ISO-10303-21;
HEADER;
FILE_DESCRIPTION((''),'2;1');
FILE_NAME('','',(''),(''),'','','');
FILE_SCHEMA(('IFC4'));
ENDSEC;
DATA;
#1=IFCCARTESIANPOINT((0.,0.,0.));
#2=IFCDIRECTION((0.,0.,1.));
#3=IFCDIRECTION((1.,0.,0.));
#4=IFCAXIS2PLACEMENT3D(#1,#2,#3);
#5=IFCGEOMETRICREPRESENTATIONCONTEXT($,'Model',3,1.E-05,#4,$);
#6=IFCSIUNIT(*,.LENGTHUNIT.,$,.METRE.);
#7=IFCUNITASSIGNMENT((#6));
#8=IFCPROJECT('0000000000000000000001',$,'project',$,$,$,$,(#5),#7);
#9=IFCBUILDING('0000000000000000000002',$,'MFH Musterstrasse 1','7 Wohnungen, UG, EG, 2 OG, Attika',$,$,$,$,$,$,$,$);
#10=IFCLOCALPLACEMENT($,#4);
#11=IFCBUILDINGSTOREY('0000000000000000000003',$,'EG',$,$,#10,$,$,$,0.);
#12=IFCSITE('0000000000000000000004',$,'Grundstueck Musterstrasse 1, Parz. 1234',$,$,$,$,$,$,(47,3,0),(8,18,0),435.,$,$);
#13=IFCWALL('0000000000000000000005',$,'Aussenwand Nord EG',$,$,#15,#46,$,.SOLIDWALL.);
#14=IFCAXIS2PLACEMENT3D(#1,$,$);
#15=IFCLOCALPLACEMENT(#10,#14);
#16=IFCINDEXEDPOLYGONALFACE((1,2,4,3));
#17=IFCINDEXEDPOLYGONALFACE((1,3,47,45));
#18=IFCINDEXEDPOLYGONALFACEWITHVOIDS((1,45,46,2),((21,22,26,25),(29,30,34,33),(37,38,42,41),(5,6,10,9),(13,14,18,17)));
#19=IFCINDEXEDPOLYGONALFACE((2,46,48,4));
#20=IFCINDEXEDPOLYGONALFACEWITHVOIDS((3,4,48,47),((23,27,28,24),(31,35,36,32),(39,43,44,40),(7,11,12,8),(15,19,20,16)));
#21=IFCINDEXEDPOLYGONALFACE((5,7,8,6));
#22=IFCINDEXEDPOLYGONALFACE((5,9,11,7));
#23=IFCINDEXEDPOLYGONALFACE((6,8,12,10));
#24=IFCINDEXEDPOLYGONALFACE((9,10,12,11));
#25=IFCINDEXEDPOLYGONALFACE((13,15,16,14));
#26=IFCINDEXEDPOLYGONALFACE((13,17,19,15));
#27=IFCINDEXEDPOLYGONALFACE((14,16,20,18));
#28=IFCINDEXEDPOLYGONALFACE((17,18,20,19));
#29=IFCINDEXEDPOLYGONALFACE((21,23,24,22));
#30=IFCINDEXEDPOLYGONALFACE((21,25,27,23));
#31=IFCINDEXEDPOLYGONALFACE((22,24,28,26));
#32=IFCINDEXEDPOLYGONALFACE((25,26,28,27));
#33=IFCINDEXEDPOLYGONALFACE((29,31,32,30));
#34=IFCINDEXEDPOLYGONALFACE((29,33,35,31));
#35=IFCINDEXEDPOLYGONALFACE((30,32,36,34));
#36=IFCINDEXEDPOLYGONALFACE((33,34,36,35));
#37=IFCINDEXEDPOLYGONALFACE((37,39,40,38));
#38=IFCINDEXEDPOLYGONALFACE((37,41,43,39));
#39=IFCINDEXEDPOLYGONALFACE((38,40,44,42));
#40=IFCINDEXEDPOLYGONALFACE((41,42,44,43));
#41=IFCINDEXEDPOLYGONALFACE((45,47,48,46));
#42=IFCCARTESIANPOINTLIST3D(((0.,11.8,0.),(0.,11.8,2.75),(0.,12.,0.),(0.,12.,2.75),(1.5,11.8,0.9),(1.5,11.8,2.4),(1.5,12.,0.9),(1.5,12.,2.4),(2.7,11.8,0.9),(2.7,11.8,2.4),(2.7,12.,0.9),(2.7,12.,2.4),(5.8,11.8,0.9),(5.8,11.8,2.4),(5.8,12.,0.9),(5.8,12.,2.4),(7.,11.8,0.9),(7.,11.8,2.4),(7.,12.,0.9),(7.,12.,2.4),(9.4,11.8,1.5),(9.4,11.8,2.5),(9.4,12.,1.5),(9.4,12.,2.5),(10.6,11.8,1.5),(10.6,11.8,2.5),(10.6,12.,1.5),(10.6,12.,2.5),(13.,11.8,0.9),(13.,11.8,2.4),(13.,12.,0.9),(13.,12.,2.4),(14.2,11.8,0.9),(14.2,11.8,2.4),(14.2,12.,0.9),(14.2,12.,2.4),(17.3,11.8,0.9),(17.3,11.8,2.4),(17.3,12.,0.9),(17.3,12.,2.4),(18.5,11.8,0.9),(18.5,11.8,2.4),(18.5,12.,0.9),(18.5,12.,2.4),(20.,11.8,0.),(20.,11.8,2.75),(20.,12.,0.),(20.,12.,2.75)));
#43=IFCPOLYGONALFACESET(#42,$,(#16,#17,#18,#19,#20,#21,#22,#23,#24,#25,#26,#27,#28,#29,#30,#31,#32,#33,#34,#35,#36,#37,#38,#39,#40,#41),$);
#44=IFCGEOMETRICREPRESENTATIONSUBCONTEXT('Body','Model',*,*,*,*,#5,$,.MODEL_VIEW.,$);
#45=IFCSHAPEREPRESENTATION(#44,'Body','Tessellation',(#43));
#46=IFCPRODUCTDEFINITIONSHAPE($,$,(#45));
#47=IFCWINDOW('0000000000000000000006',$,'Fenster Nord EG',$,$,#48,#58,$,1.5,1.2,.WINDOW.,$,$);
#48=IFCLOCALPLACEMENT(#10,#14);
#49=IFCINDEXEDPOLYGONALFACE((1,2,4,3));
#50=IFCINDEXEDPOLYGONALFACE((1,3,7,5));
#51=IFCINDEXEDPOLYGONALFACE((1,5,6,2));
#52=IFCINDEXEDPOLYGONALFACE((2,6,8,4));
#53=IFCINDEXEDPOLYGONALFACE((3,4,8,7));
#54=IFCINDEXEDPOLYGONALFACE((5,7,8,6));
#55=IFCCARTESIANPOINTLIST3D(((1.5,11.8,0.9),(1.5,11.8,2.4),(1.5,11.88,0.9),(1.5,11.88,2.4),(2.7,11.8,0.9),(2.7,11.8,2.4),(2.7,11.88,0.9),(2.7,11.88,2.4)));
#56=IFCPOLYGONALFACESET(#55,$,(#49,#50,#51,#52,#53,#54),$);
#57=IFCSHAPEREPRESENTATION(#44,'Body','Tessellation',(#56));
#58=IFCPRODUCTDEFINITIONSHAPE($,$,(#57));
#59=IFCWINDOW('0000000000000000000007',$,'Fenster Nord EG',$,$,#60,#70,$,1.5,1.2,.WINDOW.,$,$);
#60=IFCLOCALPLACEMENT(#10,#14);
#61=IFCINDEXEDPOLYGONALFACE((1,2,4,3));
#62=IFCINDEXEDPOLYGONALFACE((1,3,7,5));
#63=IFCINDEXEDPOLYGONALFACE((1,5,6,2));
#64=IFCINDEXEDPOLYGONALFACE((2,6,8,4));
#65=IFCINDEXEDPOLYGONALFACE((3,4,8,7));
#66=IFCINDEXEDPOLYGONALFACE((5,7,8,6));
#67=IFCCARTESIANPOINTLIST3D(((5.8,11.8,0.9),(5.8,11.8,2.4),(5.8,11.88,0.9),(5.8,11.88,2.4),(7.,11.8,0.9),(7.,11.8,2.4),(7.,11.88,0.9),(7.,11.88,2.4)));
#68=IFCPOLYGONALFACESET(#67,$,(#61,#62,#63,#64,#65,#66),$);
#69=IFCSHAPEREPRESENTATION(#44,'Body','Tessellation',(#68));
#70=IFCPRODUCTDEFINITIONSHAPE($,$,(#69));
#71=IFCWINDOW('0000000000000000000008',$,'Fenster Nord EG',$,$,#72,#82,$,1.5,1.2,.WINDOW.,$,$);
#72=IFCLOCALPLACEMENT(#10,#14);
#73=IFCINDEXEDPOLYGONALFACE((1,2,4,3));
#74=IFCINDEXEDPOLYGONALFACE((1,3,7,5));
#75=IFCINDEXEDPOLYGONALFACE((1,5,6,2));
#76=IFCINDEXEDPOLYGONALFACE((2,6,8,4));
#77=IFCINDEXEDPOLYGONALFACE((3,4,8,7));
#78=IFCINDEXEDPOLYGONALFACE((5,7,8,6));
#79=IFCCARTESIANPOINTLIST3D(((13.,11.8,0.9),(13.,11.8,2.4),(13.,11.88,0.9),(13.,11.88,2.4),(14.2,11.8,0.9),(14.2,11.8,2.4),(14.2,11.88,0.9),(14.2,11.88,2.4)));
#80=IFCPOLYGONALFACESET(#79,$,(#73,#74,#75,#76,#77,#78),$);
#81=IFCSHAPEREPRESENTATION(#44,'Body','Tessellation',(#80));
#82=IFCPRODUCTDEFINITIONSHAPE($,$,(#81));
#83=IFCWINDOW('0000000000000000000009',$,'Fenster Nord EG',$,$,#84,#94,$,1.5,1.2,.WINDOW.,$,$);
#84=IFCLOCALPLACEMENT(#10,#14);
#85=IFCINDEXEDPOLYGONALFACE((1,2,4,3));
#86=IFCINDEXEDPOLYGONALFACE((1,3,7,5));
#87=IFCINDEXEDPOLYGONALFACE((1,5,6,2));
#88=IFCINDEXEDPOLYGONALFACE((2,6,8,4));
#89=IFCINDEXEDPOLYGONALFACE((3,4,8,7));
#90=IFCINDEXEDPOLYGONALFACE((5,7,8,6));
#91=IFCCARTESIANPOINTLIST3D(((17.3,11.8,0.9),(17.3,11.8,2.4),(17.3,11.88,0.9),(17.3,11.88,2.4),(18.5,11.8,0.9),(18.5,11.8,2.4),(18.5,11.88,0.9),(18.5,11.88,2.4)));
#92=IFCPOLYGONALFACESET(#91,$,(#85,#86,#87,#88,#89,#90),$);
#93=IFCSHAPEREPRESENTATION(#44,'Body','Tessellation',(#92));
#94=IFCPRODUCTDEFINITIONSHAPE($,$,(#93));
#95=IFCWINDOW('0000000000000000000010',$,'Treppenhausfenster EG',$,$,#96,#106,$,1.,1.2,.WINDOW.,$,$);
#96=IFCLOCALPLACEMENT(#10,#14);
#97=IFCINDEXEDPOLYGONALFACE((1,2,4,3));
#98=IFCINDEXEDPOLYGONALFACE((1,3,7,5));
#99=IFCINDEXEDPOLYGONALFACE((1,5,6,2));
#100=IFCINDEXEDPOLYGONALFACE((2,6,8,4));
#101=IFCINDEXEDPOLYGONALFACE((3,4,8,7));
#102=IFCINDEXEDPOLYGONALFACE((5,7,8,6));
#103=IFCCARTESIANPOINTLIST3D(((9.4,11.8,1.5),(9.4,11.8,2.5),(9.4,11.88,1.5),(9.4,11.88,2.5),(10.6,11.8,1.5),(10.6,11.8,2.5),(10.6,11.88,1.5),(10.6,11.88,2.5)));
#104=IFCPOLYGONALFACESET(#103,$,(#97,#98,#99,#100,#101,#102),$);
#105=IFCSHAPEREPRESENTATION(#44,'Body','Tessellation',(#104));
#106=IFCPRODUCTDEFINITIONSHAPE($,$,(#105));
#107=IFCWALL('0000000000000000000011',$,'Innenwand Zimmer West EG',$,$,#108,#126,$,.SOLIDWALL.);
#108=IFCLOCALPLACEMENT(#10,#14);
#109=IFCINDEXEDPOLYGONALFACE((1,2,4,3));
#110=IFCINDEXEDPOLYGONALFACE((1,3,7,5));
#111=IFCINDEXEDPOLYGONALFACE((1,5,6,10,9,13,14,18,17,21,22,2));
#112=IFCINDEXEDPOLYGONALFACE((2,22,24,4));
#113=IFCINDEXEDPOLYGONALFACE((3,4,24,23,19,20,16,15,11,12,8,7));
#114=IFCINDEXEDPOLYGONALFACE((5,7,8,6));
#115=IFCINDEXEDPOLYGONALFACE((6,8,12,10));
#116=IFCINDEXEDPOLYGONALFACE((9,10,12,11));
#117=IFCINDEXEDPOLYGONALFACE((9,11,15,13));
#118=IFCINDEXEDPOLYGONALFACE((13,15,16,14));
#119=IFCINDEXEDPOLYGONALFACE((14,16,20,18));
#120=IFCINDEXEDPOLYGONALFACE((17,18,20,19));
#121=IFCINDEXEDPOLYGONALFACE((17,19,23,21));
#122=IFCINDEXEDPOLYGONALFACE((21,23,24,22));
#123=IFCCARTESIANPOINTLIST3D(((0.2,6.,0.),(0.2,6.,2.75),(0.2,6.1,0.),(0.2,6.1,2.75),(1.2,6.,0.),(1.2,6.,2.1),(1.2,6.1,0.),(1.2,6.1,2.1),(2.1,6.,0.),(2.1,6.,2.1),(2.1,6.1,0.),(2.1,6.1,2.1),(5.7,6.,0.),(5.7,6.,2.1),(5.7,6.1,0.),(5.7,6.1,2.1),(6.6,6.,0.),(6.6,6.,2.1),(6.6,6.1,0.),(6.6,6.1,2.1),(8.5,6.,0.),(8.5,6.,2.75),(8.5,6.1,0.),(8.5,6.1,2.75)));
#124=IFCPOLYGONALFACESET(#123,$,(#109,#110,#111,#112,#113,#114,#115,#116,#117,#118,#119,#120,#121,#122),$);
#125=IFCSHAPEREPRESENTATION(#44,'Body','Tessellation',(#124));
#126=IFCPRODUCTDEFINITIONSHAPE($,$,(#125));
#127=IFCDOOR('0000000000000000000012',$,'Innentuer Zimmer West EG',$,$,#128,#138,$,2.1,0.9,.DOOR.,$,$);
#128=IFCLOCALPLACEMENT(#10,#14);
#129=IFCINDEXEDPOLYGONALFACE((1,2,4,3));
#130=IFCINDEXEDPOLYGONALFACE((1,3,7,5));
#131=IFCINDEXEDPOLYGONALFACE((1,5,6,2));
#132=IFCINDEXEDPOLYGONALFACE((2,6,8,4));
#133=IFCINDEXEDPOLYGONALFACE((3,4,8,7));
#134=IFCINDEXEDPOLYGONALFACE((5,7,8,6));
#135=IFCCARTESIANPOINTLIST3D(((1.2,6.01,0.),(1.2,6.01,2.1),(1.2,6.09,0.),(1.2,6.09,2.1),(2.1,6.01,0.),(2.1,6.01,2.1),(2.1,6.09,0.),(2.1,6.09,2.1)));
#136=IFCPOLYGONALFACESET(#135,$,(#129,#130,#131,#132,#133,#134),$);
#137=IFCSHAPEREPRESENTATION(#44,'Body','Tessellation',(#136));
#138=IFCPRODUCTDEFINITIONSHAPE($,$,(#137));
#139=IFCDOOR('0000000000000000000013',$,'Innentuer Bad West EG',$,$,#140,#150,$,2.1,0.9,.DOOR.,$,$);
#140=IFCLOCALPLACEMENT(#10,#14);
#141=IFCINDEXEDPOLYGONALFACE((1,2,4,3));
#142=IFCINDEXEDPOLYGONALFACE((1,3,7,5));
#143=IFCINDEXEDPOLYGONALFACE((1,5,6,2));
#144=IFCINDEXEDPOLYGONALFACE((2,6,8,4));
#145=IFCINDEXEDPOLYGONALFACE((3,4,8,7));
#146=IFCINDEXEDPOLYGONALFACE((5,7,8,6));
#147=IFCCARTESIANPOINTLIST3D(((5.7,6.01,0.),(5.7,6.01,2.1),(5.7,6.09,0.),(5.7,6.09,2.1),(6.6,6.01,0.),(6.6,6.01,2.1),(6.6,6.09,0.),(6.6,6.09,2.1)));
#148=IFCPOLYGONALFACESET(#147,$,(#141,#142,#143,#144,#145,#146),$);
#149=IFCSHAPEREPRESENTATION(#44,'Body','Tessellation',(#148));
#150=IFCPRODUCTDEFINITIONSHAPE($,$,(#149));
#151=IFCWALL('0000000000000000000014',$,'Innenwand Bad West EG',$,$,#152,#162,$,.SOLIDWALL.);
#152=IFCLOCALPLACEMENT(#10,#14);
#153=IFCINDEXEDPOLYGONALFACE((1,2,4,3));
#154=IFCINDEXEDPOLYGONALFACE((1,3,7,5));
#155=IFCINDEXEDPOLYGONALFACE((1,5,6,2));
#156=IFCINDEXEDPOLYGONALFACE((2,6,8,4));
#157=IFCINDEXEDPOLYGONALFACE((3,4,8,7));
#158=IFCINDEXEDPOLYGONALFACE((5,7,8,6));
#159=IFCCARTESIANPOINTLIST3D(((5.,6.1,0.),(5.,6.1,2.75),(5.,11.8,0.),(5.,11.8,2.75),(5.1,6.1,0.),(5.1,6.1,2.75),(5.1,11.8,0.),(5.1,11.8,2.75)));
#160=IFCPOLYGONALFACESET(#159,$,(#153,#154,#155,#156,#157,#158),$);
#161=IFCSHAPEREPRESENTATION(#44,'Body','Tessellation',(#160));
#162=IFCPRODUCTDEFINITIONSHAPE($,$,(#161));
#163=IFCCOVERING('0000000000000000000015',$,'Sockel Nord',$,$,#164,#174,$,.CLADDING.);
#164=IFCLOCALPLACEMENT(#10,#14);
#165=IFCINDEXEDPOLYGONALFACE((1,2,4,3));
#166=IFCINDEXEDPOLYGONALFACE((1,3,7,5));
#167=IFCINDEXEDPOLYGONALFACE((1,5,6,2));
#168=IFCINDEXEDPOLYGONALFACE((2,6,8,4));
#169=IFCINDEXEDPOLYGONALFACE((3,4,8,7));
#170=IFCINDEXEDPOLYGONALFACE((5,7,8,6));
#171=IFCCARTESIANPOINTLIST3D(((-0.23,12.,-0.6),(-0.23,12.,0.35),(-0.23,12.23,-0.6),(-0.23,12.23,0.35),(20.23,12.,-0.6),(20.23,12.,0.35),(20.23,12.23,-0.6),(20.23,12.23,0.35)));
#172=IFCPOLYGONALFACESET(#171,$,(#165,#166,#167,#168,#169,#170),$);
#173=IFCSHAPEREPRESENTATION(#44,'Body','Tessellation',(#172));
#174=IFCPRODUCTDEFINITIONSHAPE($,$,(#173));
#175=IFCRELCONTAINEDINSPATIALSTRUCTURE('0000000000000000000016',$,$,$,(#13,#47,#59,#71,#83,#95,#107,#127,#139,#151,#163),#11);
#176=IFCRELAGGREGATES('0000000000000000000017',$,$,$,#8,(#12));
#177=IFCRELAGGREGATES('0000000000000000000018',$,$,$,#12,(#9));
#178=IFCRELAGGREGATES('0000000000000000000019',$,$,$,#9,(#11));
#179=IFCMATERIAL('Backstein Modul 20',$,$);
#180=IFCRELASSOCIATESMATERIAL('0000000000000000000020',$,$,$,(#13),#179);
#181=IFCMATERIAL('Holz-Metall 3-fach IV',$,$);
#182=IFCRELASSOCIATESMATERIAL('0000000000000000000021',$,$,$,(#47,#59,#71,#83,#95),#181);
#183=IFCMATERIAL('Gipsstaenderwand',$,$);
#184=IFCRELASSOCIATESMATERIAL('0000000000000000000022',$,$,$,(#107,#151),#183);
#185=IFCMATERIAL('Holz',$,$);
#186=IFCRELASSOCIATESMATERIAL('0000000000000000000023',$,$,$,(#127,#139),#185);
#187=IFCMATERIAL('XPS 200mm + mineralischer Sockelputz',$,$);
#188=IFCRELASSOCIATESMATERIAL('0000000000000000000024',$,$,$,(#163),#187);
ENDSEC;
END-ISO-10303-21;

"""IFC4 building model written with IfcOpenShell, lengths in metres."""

from ifc_helpers import new_model, si_unit, frame, frame_2d, origin_with_axes, place, context, subcontext, project, spatial, rectangle, extrude, material, element, fill, save


model = new_model("IFC4")

# Units and contexts
model_context = context("Model", 3, precision=1e-05, world=origin_with_axes())
body_context = subcontext(model_context, "Body", "Model", "MODEL_VIEW")
ifc_project = project(units=[si_unit("LENGTHUNIT", "METRE")], contexts=[model_context])

# Site, building, storey
site = spatial("IfcSite", under=ifc_project, Name="Grundstueck Musterstrasse 1, Parz. 1234", RefLatitude=(47, 3, 0), RefLongitude=(8, 18, 0), RefElevation=435.0)
building = spatial("IfcBuilding", under=site, Name="MFH Musterstrasse 1", Description="7 Wohnungen, UG, EG, 2 OG, Attika")
storey_placement = place(None, origin_with_axes())
storey = spatial("IfcBuildingStorey", under=building, at=storey_placement, Name="EG", Elevation=0.0)

# Wall, openings, windows
ifc_material_1 = material(Name="Backstein Modul 20")
wall_1_placement = place(storey_placement, frame((0.0, 11.8, 0.0), z_axis=(0.0, 0.0, 1.0), x_axis=(1.0, 0.0, 0.0)))
wall_1 = element("IfcWall", 1, at=wall_1_placement, inside=storey, material=ifc_material_1, Name="Aussenwand Nord EG", PredefinedType="SOLIDWALL", context=body_context, shape_type="SweptSolid", body=[
    extrude(rectangle(XDim=20.0, YDim=0.2, at=frame_2d((10.0, 0.1))), origin_with_axes(), (0.0, 0.0, 1.0), 2.75),
])
opening_1_placement = place(wall_1_placement, frame((1.5, -0.01, 0.9), z_axis=(0.0, 0.0, 1.0), x_axis=(1.0, 0.0, 0.0)))
opening_1 = element("IfcOpeningElement", 2, at=opening_1_placement, cuts=wall_1, context=body_context, shape_type="SweptSolid", body=[
    extrude(rectangle(XDim=1.2, YDim=0.42, at=frame_2d((0.6, 0.21))), origin_with_axes(), (0.0, 0.0, 1.0), 1.5),
])
opening_2_placement = place(wall_1_placement, frame((5.8, -0.01, 0.9), z_axis=(0.0, 0.0, 1.0), x_axis=(1.0, 0.0, 0.0)))
opening_2 = element("IfcOpeningElement", 3, at=opening_2_placement, cuts=wall_1, context=body_context, shape_type="SweptSolid", body=[
    extrude(rectangle(XDim=1.2, YDim=0.42, at=frame_2d((0.6, 0.21))), origin_with_axes(), (0.0, 0.0, 1.0), 1.5),
])
opening_3_placement = place(wall_1_placement, frame((13.0, -0.01, 0.9), z_axis=(0.0, 0.0, 1.0), x_axis=(1.0, 0.0, 0.0)))
opening_3 = element("IfcOpeningElement", 4, at=opening_3_placement, cuts=wall_1, context=body_context, shape_type="SweptSolid", body=[
    extrude(rectangle(XDim=1.2, YDim=0.42, at=frame_2d((0.6, 0.21))), origin_with_axes(), (0.0, 0.0, 1.0), 1.5),
])
opening_4_placement = place(wall_1_placement, frame((17.3, -0.01, 0.9), z_axis=(0.0, 0.0, 1.0), x_axis=(1.0, 0.0, 0.0)))
opening_4 = element("IfcOpeningElement", 5, at=opening_4_placement, cuts=wall_1, context=body_context, shape_type="SweptSolid", body=[
    extrude(rectangle(XDim=1.2, YDim=0.42, at=frame_2d((0.6, 0.21))), origin_with_axes(), (0.0, 0.0, 1.0), 1.5),
])
opening_5_placement = place(wall_1_placement, frame((9.4, -0.01, 1.5), z_axis=(0.0, 0.0, 1.0), x_axis=(1.0, 0.0, 0.0)))
opening_5 = element("IfcOpeningElement", 6, at=opening_5_placement, cuts=wall_1, context=body_context, shape_type="SweptSolid", body=[
    extrude(rectangle(XDim=1.2, YDim=0.42, at=frame_2d((0.6, 0.21))), origin_with_axes(), (0.0, 0.0, 1.0), 1.0),
])
ifc_material_2 = material(Name="Holz-Metall 3-fach IV")
window_1_placement = place(storey_placement, frame((1.5, 11.8, 0.9), z_axis=(0.0, 0.0, 1.0), x_axis=(1.0, 0.0, 0.0)))
window_1 = element("IfcWindow", 7, at=window_1_placement, inside=storey, material=ifc_material_2, Name="Fenster Nord EG", OverallHeight=1.5, OverallWidth=1.2, PredefinedType="WINDOW", context=body_context, shape_type="SweptSolid", body=[
    extrude(rectangle(XDim=1.2, YDim=0.08, at=frame_2d((0.6, 0.04))), origin_with_axes(), (0.0, 0.0, 1.0), 1.5),
])
fill(opening_1, window_1)
window_2_placement = place(storey_placement, frame((5.8, 11.8, 0.9), z_axis=(0.0, 0.0, 1.0), x_axis=(1.0, 0.0, 0.0)))
window_2 = element("IfcWindow", 8, at=window_2_placement, inside=storey, material=ifc_material_2, Name="Fenster Nord EG", OverallHeight=1.5, OverallWidth=1.2, PredefinedType="WINDOW", context=body_context, shape_type="SweptSolid", body=[
    extrude(rectangle(XDim=1.2, YDim=0.08, at=frame_2d((0.6, 0.04))), origin_with_axes(), (0.0, 0.0, 1.0), 1.5),
])
fill(opening_2, window_2)
window_3_placement = place(storey_placement, frame((13.0, 11.8, 0.9), z_axis=(0.0, 0.0, 1.0), x_axis=(1.0, 0.0, 0.0)))
window_3 = element("IfcWindow", 9, at=window_3_placement, inside=storey, material=ifc_material_2, Name="Fenster Nord EG", OverallHeight=1.5, OverallWidth=1.2, PredefinedType="WINDOW", context=body_context, shape_type="SweptSolid", body=[
    extrude(rectangle(XDim=1.2, YDim=0.08, at=frame_2d((0.6, 0.04))), origin_with_axes(), (0.0, 0.0, 1.0), 1.5),
])
fill(opening_3, window_3)
window_4_placement = place(storey_placement, frame((17.3, 11.8, 0.9), z_axis=(0.0, 0.0, 1.0), x_axis=(1.0, 0.0, 0.0)))
window_4 = element("IfcWindow", 10, at=window_4_placement, inside=storey, material=ifc_material_2, Name="Fenster Nord EG", OverallHeight=1.5, OverallWidth=1.2, PredefinedType="WINDOW", context=body_context, shape_type="SweptSolid", body=[
    extrude(rectangle(XDim=1.2, YDim=0.08, at=frame_2d((0.6, 0.04))), origin_with_axes(), (0.0, 0.0, 1.0), 1.5),
])
fill(opening_4, window_4)
window_5_placement = place(storey_placement, frame((9.4, 11.8, 1.5), z_axis=(0.0, 0.0, 1.0), x_axis=(1.0, 0.0, 0.0)))
window_5 = element("IfcWindow", 11, at=window_5_placement, inside=storey, material=ifc_material_2, Name="Treppenhausfenster EG", OverallHeight=1.0, OverallWidth=1.2, PredefinedType="WINDOW", context=body_context, shape_type="SweptSolid", body=[
    extrude(rectangle(XDim=1.2, YDim=0.08, at=frame_2d((0.6, 0.04))), origin_with_axes(), (0.0, 0.0, 1.0), 1.0),
])
fill(opening_5, window_5)

# Wall, openings, doors
ifc_material_3 = material(Name="Gipsstaenderwand")
wall_2_placement = place(storey_placement, frame((0.2, 6.0, 0.0), z_axis=(0.0, 0.0, 1.0), x_axis=(1.0, 0.0, 0.0)))
wall_2 = element("IfcWall", 12, at=wall_2_placement, inside=storey, material=ifc_material_3, Name="Innenwand Zimmer West EG", PredefinedType="SOLIDWALL", context=body_context, shape_type="SweptSolid", body=[
    extrude(rectangle(XDim=8.3, YDim=0.1, at=frame_2d((4.15, 0.05))), origin_with_axes(), (0.0, 0.0, 1.0), 2.75),
])
opening_6_placement = place(wall_2_placement, frame((1.0, -0.01, 0.0), z_axis=(0.0, 0.0, 1.0), x_axis=(1.0, 0.0, 0.0)))
opening_6 = element("IfcOpeningElement", 13, at=opening_6_placement, cuts=wall_2, context=body_context, shape_type="SweptSolid", body=[
    extrude(rectangle(XDim=0.9, YDim=0.12, at=frame_2d((0.45, 0.06))), origin_with_axes(), (0.0, 0.0, 1.0), 2.1),
])
opening_7_placement = place(wall_2_placement, frame((5.5, -0.01, 0.0), z_axis=(0.0, 0.0, 1.0), x_axis=(1.0, 0.0, 0.0)))
opening_7 = element("IfcOpeningElement", 14, at=opening_7_placement, cuts=wall_2, context=body_context, shape_type="SweptSolid", body=[
    extrude(rectangle(XDim=0.9, YDim=0.12, at=frame_2d((0.45, 0.06))), origin_with_axes(), (0.0, 0.0, 1.0), 2.1),
])
ifc_material_4 = material(Name="Holz")
door_1_placement = place(storey_placement, frame((1.2, 6.01, 0.0), z_axis=(0.0, 0.0, 1.0), x_axis=(1.0, 0.0, 0.0)))
door_1 = element("IfcDoor", 15, at=door_1_placement, inside=storey, material=ifc_material_4, Name="Innentuer Zimmer West EG", OverallHeight=2.1, OverallWidth=0.9, PredefinedType="DOOR", context=body_context, shape_type="SweptSolid", body=[
    extrude(rectangle(XDim=0.9, YDim=0.08, at=frame_2d((0.45, 0.04))), origin_with_axes(), (0.0, 0.0, 1.0), 2.1),
])
fill(opening_6, door_1)
door_2_placement = place(storey_placement, frame((5.7, 6.01, 0.0), z_axis=(0.0, 0.0, 1.0), x_axis=(1.0, 0.0, 0.0)))
door_2 = element("IfcDoor", 16, at=door_2_placement, inside=storey, material=ifc_material_4, Name="Innentuer Bad West EG", OverallHeight=2.1, OverallWidth=0.9, PredefinedType="DOOR", context=body_context, shape_type="SweptSolid", body=[
    extrude(rectangle(XDim=0.9, YDim=0.08, at=frame_2d((0.45, 0.04))), origin_with_axes(), (0.0, 0.0, 1.0), 2.1),
])
fill(opening_7, door_2)

# Wall
wall_3_placement = place(storey_placement, frame((5.0, 6.1, 0.0), z_axis=(0.0, 0.0, 1.0), x_axis=(1.0, 0.0, 0.0)))
element("IfcWall", 17, at=wall_3_placement, inside=storey, material=ifc_material_3, Name="Innenwand Bad West EG", PredefinedType="SOLIDWALL", context=body_context, shape_type="SweptSolid", body=[
    extrude(rectangle(XDim=0.1, YDim=5.7, at=frame_2d((0.05, 2.85))), origin_with_axes(), (0.0, 0.0, 1.0), 2.75),
])

# Covering
ifc_material_5 = material(Name="XPS 200mm + mineralischer Sockelputz")
covering_1_placement = place(storey_placement, frame((-0.23, 12.0, -0.6), z_axis=(0.0, 0.0, 1.0), x_axis=(1.0, 0.0, 0.0)))
element("IfcCovering", 18, at=covering_1_placement, inside=storey, material=ifc_material_5, Name="Sockel Nord", PredefinedType="CLADDING", context=body_context, shape_type="SweptSolid", body=[
    extrude(rectangle(XDim=20.46, YDim=0.23, at=frame_2d((10.23, 0.115))), origin_with_axes(), (0.0, 0.0, 1.0), 0.95),
])

save(model, "model.ifc")
